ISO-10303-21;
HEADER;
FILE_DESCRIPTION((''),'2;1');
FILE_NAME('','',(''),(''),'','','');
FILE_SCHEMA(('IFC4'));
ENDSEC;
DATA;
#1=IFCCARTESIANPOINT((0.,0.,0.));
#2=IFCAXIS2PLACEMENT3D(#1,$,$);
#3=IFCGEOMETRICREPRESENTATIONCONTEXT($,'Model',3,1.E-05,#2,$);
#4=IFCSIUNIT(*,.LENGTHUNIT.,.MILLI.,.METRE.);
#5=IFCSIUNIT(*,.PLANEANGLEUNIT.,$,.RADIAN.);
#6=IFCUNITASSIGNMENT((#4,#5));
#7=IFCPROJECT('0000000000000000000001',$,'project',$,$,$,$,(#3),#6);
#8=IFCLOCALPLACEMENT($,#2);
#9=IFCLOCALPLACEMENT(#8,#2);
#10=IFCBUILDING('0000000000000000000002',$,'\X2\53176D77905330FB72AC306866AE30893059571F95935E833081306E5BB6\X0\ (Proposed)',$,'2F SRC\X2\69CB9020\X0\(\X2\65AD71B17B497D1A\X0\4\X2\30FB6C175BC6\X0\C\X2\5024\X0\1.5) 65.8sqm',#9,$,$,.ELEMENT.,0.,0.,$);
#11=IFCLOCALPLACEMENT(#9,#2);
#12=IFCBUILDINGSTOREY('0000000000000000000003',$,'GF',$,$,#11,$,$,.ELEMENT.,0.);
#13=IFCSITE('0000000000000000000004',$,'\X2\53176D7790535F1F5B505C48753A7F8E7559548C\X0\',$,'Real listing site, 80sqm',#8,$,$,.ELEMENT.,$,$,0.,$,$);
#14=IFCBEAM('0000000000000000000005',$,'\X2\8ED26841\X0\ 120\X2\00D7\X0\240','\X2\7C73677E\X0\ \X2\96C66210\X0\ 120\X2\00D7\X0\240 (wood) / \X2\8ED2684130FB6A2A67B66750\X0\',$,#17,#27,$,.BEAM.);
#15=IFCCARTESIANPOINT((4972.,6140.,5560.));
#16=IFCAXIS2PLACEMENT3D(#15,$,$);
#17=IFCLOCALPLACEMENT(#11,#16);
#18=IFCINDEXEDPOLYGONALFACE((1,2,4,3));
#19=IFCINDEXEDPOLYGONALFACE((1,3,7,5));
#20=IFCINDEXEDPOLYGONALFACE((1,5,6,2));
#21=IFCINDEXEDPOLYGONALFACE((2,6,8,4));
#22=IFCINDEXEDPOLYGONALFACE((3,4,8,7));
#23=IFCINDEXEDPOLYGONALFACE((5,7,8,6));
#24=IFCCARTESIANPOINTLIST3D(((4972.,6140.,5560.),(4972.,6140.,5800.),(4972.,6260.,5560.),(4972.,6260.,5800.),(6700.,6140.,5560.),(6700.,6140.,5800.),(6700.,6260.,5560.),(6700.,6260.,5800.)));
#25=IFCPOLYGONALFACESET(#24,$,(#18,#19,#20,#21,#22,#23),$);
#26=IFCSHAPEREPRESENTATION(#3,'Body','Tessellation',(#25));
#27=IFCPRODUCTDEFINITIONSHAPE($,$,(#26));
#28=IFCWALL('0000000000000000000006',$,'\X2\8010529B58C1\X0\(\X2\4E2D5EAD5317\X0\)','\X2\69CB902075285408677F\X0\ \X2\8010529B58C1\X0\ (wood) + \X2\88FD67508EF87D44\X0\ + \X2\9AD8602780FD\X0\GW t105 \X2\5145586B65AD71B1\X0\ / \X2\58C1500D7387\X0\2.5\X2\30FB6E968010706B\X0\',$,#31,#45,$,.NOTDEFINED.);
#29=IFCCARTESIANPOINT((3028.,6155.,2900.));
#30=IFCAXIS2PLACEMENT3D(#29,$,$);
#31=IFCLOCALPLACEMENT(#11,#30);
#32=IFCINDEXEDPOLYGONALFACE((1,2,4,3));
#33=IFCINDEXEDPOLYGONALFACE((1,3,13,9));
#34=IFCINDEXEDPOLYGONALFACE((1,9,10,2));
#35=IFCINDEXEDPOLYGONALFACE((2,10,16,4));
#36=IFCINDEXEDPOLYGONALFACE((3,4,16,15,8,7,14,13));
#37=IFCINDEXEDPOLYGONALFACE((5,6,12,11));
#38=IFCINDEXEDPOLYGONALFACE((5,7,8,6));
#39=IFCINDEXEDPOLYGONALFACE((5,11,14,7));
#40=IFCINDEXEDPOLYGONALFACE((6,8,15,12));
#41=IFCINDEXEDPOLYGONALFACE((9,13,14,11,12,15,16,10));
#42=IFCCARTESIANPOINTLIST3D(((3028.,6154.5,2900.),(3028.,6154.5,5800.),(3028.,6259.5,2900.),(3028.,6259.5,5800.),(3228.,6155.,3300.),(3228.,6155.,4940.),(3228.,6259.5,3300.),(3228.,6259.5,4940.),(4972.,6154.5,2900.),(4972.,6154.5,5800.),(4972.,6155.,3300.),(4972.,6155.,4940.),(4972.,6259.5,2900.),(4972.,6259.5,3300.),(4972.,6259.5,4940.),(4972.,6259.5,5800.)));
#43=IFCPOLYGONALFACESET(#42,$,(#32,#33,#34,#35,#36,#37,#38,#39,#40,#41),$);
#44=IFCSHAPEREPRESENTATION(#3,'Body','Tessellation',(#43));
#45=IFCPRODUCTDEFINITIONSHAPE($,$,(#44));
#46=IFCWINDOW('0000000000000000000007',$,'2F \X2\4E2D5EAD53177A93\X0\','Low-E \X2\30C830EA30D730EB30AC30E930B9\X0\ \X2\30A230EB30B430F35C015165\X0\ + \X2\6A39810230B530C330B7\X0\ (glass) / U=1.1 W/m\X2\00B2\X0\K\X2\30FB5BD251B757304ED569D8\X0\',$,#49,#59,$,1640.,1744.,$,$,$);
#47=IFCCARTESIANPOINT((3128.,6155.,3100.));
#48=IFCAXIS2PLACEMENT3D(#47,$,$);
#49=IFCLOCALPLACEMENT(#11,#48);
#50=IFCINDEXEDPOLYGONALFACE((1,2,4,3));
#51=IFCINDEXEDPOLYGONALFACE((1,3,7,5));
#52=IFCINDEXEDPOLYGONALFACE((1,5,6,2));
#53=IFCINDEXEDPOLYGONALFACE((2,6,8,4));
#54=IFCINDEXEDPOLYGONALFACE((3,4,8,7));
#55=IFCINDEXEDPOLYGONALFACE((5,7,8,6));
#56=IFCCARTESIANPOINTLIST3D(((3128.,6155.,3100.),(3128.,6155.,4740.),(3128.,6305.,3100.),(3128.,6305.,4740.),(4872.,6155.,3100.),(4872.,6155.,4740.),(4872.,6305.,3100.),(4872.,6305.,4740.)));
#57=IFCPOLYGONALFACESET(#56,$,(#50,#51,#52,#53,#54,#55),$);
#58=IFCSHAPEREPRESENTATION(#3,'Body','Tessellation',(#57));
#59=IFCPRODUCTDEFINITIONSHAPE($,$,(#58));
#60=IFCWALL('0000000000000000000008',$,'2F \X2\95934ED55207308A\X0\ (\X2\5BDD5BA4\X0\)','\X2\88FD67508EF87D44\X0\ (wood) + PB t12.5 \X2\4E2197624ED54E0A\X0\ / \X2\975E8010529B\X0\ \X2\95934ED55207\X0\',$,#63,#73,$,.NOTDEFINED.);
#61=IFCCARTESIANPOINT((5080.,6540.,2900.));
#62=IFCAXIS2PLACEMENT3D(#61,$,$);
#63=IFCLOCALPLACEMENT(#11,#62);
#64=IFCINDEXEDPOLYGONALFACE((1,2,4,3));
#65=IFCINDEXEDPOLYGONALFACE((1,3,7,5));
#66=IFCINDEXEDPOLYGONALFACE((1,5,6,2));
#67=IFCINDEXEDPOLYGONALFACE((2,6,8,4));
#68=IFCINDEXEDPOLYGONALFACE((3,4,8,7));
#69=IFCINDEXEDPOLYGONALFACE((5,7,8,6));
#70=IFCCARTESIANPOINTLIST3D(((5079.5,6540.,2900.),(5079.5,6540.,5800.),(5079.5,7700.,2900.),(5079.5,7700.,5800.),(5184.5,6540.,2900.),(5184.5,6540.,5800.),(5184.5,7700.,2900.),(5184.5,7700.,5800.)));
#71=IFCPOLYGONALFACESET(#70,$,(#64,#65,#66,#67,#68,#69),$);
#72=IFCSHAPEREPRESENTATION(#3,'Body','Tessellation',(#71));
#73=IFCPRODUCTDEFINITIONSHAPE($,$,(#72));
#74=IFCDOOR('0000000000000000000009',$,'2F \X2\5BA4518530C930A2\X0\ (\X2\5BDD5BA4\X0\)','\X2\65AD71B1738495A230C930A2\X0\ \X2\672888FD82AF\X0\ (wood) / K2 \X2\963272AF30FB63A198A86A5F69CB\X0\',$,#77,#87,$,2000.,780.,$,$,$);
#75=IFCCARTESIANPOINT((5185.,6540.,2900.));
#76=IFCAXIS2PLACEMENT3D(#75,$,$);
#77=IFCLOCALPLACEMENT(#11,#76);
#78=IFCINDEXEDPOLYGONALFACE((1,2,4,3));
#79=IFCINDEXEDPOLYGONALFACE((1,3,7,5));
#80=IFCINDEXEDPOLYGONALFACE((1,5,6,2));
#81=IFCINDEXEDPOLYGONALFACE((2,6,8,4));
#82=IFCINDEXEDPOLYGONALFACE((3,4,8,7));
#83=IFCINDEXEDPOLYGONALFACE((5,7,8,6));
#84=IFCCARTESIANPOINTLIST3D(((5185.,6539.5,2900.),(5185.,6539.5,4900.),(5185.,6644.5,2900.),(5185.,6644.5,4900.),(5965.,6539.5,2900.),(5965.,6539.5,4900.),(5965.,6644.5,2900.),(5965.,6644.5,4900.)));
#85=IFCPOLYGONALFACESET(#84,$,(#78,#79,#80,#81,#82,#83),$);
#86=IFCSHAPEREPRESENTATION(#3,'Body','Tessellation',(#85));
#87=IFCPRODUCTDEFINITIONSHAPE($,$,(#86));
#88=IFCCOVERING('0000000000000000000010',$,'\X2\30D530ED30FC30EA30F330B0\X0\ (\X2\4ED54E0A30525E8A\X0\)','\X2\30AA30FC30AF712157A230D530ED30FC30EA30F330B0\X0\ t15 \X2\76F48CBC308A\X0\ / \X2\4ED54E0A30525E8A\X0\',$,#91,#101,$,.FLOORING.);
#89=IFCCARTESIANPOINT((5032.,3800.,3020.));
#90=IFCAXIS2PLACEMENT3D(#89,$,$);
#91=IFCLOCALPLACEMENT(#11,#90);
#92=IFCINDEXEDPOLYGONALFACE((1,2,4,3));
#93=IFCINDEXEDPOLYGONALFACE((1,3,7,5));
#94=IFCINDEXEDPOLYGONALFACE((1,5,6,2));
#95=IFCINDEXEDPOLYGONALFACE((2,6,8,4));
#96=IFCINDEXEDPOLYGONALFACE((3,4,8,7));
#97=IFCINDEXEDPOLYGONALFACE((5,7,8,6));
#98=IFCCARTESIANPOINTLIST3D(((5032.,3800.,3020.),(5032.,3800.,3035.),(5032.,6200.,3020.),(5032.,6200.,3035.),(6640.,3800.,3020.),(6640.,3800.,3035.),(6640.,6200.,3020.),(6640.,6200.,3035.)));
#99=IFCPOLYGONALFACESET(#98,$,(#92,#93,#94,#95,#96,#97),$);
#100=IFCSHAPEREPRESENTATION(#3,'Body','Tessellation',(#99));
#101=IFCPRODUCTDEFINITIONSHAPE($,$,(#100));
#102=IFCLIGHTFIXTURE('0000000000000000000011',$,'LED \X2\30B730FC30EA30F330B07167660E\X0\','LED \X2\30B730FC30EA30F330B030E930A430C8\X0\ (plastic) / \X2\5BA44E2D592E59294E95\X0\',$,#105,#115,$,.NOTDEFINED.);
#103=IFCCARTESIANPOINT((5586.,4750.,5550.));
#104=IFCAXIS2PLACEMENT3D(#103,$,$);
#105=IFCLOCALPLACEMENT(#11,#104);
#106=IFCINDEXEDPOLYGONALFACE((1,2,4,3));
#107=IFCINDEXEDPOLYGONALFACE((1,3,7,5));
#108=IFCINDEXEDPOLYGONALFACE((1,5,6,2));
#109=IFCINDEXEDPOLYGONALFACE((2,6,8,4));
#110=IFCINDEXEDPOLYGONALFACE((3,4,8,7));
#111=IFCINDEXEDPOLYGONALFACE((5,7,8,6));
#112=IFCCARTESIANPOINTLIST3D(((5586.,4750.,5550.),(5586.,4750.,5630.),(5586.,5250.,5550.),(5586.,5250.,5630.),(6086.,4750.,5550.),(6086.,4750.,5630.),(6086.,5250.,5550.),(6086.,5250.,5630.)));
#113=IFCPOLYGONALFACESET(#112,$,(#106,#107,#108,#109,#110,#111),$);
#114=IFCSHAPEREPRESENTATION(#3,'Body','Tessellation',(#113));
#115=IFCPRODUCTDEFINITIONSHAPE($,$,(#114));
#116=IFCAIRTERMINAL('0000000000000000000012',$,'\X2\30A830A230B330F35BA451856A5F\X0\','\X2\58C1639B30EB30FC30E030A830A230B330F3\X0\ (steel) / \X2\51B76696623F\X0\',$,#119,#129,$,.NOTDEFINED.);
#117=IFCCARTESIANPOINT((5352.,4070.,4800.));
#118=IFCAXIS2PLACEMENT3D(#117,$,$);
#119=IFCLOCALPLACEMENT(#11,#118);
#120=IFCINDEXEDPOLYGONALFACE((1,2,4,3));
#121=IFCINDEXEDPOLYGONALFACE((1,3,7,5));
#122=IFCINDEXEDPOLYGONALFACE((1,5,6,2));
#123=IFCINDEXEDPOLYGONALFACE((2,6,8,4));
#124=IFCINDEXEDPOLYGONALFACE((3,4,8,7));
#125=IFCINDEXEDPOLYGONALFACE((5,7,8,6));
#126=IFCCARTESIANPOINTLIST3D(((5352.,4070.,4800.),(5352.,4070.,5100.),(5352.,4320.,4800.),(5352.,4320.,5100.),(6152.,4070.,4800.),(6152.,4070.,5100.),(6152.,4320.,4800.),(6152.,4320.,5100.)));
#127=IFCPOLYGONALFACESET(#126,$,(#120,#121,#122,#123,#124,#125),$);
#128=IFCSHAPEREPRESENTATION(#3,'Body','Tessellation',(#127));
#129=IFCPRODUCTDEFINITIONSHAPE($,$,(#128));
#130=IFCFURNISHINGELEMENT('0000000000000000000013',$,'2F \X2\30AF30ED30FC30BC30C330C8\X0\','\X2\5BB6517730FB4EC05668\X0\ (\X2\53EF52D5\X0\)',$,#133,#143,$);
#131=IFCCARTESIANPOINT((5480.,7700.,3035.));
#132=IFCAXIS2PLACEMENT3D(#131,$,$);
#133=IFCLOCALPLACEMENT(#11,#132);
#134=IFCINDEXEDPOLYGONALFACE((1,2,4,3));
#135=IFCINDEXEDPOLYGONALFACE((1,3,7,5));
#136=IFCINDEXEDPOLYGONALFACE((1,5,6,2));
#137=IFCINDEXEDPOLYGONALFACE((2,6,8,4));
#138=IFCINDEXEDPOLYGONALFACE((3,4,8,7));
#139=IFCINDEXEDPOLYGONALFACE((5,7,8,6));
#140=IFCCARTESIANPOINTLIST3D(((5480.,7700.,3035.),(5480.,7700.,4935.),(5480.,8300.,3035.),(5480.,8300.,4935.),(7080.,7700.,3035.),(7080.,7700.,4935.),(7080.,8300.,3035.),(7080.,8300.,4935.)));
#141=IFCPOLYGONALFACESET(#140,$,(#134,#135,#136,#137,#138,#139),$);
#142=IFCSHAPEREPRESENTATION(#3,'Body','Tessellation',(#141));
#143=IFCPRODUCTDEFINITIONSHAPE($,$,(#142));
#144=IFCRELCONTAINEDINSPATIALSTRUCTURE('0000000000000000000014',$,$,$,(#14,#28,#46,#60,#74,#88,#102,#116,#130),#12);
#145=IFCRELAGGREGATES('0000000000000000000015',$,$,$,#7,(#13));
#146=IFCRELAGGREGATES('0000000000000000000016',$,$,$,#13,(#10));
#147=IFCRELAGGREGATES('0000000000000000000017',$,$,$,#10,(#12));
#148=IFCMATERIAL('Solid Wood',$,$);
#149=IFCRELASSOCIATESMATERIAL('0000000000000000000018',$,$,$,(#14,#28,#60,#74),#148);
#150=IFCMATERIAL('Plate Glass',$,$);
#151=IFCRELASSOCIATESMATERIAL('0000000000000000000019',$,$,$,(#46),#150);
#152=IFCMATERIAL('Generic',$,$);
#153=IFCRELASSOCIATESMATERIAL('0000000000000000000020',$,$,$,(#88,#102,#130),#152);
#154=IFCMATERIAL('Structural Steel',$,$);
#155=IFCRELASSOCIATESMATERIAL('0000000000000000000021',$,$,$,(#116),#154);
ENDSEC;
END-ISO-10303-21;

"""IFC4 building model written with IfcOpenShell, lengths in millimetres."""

from ifc_helpers import new_model, si_unit, frame, frame_2d, origin, place, context, project, spatial, rectangle, extrude, material, element, fill, save


model = new_model("IFC4")

# Units and contexts
model_context = context("Model", 3, precision=1e-05, world=origin())
ifc_project = project(units=[si_unit("LENGTHUNIT", "METRE", prefix="MILLI"), si_unit("PLANEANGLEUNIT", "RADIAN")], contexts=[model_context])

# Site, building, storey
site_placement = place(None, origin())
site = spatial("IfcSite", under=ifc_project, at=site_placement, Name="北海道弟子屈町美留和", ObjectType="Real listing site, 80sqm", CompositionType="ELEMENT", RefElevation=0.0)
building_placement = place(site_placement, origin())
building = spatial("IfcBuilding", under=site, at=building_placement, Name="北海道・犬と暮らす土間広めの家 (Proposed)", ObjectType="2F SRC構造(断熱等級4・気密C値1.5) 65.8sqm", CompositionType="ELEMENT", ElevationOfRefHeight=0.0, ElevationOfTerrain=0.0)
storey_placement = place(building_placement, origin())
storey = spatial("IfcBuildingStorey", under=building, at=storey_placement, Name="GF", CompositionType="ELEMENT", Elevation=0.0)

# Shared definitions
ifc_material_1 = material(Name="Solid Wood")

# Beam
beam_1_placement = place(storey_placement, frame((4972.0, 6140.0, 5560.0)))
element("IfcBeam", 1, at=beam_1_placement, inside=storey, material=ifc_material_1, Name="軒桁 120×240", Description="米松 集成 120×240 (wood) / 軒桁・横架材", PredefinedType="BEAM", context=model_context, shape_type="SweptSolid", body=[
    extrude(rectangle(XDim=1728.0, YDim=120.0, at=frame_2d((864.0, 60.0))), frame((4972.0, 6140.0, 5560.0)), (0.0, 0.0, 1.0), 240.0),
])

# Wall, opening, window
wall_1_placement = place(storey_placement, frame((3028.0, 6155.0, 2900.0)))
wall_1 = element("IfcWall", 2, at=wall_1_placement, inside=storey, material=ifc_material_1, Name="耐力壁(中庭北)", Description="構造用合板 耐力壁 (wood) + 製材軸組 + 高性能GW t105 充填断熱 / 壁倍率2.5・準耐火", PredefinedType="NOTDEFINED", context=model_context, shape_type="SweptSolid", body=[
    extrude(rectangle(XDim=1944.0, YDim=105.0, at=frame_2d((972.0, 52.0))), frame((3028.0, 6155.0, 2900.0)), (0.0, 0.0, 1.0), 2900.0),
])
opening_placement = place(storey_placement, frame((3128.0, 6155.0, 3100.0)))
opening = element("IfcOpeningElement", 3, at=opening_placement, cuts=wall_1, PredefinedType="NOTDEFINED", context=model_context, shape_type="SweptSolid", body=[
    extrude(rectangle(XDim=1744.0, YDim=150.0, at=frame_2d((872.0, 75.0))), frame((3128.0, 6155.0, 3100.0)), (0.0, 0.0, 1.0), 1640.0),
])
ifc_material_2 = material(Name="Plate Glass")
window_placement = place(storey_placement, frame((3128.0, 6155.0, 3100.0)))
window = element("IfcWindow", 4, at=window_placement, inside=storey, material=ifc_material_2, Name="2F 中庭北窓", Description="Low-E トリプルガラス アルゴン封入 + 樹脂サッシ (glass) / U=1.1 W/m²K・寒冷地仕様", OverallHeight=1640.0, OverallWidth=1744.0, context=model_context, shape_type="SweptSolid", body=[
    extrude(rectangle(XDim=1744.0, YDim=150.0, at=frame_2d((872.0, 75.0))), frame((3128.0, 6155.0, 3100.0)), (0.0, 0.0, 1.0), 1640.0),
])
fill(opening, window)

# Wall
wall_2_placement = place(storey_placement, frame((5080.0, 6540.0, 2900.0)))
element("IfcWall", 5, at=wall_2_placement, inside=storey, material=ifc_material_1, Name="2F 間仕切り (寝室)", Description="製材軸組 (wood) + PB t12.5 両面仕上 / 非耐力 間仕切", PredefinedType="NOTDEFINED", context=model_context, shape_type="SweptSolid", body=[
    extrude(rectangle(XDim=105.0, YDim=1160.0, at=frame_2d((52.0, 580.0))), frame((5080.0, 6540.0, 2900.0)), (0.0, 0.0, 1.0), 2900.0),
])

# Door
door_placement = place(storey_placement, frame((5185.0, 6540.0, 2900.0)))
element("IfcDoor", 6, at=door_placement, inside=storey, material=ifc_material_1, Name="2F 室内ドア (寝室)", Description="断熱玄関ドア 木製芯 (wood) / K2 防犯・採風機構", OverallHeight=2000.0, OverallWidth=780.0, context=model_context, shape_type="SweptSolid", body=[
    extrude(rectangle(XDim=780.0, YDim=105.0, at=frame_2d((390.0, 52.0))), frame((5185.0, 6540.0, 2900.0)), (0.0, 0.0, 1.0), 2000.0),
])

# Covering
ifc_material_3 = material(Name="Generic")
covering_placement = place(storey_placement, frame((5032.0, 3800.0, 3020.0)))
element("IfcCovering", 7, at=covering_placement, inside=storey, material=ifc_material_3, Name="フローリング (仕上げ床)", Description="オーク無垢フローリング t15 直貼り / 仕上げ床", PredefinedType="FLOORING", context=model_context, shape_type="SweptSolid", body=[
    extrude(rectangle(XDim=1608.0, YDim=2400.0, at=frame_2d((804.0, 1200.0))), frame((5032.0, 3800.0, 3020.0)), (0.0, 0.0, 1.0), 15.0),
])

# Light fixture
light_fixture_placement = place(storey_placement, frame((5586.0, 4750.0, 5550.0)))
element("IfcLightFixture", 8, at=light_fixture_placement, inside=storey, material=ifc_material_3, Name="LED シーリング照明", Description="LED シーリングライト (plastic) / 室中央天井", PredefinedType="NOTDEFINED", context=model_context, shape_type="SweptSolid", body=[
    extrude(rectangle(XDim=500.0, YDim=500.0, at=frame_2d((250.0, 250.0))), frame((5586.0, 4750.0, 5550.0)), (0.0, 0.0, 1.0), 80.0),
])

# Air terminal
ifc_material_4 = material(Name="Structural Steel")
air_terminal_placement = place(storey_placement, frame((5352.0, 4070.0, 4800.0)))
element("IfcAirTerminal", 9, at=air_terminal_placement, inside=storey, material=ifc_material_4, Name="エアコン室内機", Description="壁掛ルームエアコン (steel) / 冷暖房", PredefinedType="NOTDEFINED", context=model_context, shape_type="SweptSolid", body=[
    extrude(rectangle(XDim=800.0, YDim=250.0, at=frame_2d((400.0, 125.0))), frame((5352.0, 4070.0, 4800.0)), (0.0, 0.0, 1.0), 300.0),
])

# Furnishing element
furnishing_placement = place(storey_placement, frame((5480.0, 7700.0, 3035.0)))
element("IfcFurnishingElement", 10, at=furnishing_placement, inside=storey, material=ifc_material_3, Name="2F クローゼット", Description="家具・什器 (可動)", context=model_context, shape_type="SweptSolid", body=[
    extrude(rectangle(XDim=1600.0, YDim=600.0, at=frame_2d((800.0, 300.0))), frame((5480.0, 7700.0, 3035.0)), (0.0, 0.0, 1.0), 1900.0),
])

save(model, "model.ifc")
